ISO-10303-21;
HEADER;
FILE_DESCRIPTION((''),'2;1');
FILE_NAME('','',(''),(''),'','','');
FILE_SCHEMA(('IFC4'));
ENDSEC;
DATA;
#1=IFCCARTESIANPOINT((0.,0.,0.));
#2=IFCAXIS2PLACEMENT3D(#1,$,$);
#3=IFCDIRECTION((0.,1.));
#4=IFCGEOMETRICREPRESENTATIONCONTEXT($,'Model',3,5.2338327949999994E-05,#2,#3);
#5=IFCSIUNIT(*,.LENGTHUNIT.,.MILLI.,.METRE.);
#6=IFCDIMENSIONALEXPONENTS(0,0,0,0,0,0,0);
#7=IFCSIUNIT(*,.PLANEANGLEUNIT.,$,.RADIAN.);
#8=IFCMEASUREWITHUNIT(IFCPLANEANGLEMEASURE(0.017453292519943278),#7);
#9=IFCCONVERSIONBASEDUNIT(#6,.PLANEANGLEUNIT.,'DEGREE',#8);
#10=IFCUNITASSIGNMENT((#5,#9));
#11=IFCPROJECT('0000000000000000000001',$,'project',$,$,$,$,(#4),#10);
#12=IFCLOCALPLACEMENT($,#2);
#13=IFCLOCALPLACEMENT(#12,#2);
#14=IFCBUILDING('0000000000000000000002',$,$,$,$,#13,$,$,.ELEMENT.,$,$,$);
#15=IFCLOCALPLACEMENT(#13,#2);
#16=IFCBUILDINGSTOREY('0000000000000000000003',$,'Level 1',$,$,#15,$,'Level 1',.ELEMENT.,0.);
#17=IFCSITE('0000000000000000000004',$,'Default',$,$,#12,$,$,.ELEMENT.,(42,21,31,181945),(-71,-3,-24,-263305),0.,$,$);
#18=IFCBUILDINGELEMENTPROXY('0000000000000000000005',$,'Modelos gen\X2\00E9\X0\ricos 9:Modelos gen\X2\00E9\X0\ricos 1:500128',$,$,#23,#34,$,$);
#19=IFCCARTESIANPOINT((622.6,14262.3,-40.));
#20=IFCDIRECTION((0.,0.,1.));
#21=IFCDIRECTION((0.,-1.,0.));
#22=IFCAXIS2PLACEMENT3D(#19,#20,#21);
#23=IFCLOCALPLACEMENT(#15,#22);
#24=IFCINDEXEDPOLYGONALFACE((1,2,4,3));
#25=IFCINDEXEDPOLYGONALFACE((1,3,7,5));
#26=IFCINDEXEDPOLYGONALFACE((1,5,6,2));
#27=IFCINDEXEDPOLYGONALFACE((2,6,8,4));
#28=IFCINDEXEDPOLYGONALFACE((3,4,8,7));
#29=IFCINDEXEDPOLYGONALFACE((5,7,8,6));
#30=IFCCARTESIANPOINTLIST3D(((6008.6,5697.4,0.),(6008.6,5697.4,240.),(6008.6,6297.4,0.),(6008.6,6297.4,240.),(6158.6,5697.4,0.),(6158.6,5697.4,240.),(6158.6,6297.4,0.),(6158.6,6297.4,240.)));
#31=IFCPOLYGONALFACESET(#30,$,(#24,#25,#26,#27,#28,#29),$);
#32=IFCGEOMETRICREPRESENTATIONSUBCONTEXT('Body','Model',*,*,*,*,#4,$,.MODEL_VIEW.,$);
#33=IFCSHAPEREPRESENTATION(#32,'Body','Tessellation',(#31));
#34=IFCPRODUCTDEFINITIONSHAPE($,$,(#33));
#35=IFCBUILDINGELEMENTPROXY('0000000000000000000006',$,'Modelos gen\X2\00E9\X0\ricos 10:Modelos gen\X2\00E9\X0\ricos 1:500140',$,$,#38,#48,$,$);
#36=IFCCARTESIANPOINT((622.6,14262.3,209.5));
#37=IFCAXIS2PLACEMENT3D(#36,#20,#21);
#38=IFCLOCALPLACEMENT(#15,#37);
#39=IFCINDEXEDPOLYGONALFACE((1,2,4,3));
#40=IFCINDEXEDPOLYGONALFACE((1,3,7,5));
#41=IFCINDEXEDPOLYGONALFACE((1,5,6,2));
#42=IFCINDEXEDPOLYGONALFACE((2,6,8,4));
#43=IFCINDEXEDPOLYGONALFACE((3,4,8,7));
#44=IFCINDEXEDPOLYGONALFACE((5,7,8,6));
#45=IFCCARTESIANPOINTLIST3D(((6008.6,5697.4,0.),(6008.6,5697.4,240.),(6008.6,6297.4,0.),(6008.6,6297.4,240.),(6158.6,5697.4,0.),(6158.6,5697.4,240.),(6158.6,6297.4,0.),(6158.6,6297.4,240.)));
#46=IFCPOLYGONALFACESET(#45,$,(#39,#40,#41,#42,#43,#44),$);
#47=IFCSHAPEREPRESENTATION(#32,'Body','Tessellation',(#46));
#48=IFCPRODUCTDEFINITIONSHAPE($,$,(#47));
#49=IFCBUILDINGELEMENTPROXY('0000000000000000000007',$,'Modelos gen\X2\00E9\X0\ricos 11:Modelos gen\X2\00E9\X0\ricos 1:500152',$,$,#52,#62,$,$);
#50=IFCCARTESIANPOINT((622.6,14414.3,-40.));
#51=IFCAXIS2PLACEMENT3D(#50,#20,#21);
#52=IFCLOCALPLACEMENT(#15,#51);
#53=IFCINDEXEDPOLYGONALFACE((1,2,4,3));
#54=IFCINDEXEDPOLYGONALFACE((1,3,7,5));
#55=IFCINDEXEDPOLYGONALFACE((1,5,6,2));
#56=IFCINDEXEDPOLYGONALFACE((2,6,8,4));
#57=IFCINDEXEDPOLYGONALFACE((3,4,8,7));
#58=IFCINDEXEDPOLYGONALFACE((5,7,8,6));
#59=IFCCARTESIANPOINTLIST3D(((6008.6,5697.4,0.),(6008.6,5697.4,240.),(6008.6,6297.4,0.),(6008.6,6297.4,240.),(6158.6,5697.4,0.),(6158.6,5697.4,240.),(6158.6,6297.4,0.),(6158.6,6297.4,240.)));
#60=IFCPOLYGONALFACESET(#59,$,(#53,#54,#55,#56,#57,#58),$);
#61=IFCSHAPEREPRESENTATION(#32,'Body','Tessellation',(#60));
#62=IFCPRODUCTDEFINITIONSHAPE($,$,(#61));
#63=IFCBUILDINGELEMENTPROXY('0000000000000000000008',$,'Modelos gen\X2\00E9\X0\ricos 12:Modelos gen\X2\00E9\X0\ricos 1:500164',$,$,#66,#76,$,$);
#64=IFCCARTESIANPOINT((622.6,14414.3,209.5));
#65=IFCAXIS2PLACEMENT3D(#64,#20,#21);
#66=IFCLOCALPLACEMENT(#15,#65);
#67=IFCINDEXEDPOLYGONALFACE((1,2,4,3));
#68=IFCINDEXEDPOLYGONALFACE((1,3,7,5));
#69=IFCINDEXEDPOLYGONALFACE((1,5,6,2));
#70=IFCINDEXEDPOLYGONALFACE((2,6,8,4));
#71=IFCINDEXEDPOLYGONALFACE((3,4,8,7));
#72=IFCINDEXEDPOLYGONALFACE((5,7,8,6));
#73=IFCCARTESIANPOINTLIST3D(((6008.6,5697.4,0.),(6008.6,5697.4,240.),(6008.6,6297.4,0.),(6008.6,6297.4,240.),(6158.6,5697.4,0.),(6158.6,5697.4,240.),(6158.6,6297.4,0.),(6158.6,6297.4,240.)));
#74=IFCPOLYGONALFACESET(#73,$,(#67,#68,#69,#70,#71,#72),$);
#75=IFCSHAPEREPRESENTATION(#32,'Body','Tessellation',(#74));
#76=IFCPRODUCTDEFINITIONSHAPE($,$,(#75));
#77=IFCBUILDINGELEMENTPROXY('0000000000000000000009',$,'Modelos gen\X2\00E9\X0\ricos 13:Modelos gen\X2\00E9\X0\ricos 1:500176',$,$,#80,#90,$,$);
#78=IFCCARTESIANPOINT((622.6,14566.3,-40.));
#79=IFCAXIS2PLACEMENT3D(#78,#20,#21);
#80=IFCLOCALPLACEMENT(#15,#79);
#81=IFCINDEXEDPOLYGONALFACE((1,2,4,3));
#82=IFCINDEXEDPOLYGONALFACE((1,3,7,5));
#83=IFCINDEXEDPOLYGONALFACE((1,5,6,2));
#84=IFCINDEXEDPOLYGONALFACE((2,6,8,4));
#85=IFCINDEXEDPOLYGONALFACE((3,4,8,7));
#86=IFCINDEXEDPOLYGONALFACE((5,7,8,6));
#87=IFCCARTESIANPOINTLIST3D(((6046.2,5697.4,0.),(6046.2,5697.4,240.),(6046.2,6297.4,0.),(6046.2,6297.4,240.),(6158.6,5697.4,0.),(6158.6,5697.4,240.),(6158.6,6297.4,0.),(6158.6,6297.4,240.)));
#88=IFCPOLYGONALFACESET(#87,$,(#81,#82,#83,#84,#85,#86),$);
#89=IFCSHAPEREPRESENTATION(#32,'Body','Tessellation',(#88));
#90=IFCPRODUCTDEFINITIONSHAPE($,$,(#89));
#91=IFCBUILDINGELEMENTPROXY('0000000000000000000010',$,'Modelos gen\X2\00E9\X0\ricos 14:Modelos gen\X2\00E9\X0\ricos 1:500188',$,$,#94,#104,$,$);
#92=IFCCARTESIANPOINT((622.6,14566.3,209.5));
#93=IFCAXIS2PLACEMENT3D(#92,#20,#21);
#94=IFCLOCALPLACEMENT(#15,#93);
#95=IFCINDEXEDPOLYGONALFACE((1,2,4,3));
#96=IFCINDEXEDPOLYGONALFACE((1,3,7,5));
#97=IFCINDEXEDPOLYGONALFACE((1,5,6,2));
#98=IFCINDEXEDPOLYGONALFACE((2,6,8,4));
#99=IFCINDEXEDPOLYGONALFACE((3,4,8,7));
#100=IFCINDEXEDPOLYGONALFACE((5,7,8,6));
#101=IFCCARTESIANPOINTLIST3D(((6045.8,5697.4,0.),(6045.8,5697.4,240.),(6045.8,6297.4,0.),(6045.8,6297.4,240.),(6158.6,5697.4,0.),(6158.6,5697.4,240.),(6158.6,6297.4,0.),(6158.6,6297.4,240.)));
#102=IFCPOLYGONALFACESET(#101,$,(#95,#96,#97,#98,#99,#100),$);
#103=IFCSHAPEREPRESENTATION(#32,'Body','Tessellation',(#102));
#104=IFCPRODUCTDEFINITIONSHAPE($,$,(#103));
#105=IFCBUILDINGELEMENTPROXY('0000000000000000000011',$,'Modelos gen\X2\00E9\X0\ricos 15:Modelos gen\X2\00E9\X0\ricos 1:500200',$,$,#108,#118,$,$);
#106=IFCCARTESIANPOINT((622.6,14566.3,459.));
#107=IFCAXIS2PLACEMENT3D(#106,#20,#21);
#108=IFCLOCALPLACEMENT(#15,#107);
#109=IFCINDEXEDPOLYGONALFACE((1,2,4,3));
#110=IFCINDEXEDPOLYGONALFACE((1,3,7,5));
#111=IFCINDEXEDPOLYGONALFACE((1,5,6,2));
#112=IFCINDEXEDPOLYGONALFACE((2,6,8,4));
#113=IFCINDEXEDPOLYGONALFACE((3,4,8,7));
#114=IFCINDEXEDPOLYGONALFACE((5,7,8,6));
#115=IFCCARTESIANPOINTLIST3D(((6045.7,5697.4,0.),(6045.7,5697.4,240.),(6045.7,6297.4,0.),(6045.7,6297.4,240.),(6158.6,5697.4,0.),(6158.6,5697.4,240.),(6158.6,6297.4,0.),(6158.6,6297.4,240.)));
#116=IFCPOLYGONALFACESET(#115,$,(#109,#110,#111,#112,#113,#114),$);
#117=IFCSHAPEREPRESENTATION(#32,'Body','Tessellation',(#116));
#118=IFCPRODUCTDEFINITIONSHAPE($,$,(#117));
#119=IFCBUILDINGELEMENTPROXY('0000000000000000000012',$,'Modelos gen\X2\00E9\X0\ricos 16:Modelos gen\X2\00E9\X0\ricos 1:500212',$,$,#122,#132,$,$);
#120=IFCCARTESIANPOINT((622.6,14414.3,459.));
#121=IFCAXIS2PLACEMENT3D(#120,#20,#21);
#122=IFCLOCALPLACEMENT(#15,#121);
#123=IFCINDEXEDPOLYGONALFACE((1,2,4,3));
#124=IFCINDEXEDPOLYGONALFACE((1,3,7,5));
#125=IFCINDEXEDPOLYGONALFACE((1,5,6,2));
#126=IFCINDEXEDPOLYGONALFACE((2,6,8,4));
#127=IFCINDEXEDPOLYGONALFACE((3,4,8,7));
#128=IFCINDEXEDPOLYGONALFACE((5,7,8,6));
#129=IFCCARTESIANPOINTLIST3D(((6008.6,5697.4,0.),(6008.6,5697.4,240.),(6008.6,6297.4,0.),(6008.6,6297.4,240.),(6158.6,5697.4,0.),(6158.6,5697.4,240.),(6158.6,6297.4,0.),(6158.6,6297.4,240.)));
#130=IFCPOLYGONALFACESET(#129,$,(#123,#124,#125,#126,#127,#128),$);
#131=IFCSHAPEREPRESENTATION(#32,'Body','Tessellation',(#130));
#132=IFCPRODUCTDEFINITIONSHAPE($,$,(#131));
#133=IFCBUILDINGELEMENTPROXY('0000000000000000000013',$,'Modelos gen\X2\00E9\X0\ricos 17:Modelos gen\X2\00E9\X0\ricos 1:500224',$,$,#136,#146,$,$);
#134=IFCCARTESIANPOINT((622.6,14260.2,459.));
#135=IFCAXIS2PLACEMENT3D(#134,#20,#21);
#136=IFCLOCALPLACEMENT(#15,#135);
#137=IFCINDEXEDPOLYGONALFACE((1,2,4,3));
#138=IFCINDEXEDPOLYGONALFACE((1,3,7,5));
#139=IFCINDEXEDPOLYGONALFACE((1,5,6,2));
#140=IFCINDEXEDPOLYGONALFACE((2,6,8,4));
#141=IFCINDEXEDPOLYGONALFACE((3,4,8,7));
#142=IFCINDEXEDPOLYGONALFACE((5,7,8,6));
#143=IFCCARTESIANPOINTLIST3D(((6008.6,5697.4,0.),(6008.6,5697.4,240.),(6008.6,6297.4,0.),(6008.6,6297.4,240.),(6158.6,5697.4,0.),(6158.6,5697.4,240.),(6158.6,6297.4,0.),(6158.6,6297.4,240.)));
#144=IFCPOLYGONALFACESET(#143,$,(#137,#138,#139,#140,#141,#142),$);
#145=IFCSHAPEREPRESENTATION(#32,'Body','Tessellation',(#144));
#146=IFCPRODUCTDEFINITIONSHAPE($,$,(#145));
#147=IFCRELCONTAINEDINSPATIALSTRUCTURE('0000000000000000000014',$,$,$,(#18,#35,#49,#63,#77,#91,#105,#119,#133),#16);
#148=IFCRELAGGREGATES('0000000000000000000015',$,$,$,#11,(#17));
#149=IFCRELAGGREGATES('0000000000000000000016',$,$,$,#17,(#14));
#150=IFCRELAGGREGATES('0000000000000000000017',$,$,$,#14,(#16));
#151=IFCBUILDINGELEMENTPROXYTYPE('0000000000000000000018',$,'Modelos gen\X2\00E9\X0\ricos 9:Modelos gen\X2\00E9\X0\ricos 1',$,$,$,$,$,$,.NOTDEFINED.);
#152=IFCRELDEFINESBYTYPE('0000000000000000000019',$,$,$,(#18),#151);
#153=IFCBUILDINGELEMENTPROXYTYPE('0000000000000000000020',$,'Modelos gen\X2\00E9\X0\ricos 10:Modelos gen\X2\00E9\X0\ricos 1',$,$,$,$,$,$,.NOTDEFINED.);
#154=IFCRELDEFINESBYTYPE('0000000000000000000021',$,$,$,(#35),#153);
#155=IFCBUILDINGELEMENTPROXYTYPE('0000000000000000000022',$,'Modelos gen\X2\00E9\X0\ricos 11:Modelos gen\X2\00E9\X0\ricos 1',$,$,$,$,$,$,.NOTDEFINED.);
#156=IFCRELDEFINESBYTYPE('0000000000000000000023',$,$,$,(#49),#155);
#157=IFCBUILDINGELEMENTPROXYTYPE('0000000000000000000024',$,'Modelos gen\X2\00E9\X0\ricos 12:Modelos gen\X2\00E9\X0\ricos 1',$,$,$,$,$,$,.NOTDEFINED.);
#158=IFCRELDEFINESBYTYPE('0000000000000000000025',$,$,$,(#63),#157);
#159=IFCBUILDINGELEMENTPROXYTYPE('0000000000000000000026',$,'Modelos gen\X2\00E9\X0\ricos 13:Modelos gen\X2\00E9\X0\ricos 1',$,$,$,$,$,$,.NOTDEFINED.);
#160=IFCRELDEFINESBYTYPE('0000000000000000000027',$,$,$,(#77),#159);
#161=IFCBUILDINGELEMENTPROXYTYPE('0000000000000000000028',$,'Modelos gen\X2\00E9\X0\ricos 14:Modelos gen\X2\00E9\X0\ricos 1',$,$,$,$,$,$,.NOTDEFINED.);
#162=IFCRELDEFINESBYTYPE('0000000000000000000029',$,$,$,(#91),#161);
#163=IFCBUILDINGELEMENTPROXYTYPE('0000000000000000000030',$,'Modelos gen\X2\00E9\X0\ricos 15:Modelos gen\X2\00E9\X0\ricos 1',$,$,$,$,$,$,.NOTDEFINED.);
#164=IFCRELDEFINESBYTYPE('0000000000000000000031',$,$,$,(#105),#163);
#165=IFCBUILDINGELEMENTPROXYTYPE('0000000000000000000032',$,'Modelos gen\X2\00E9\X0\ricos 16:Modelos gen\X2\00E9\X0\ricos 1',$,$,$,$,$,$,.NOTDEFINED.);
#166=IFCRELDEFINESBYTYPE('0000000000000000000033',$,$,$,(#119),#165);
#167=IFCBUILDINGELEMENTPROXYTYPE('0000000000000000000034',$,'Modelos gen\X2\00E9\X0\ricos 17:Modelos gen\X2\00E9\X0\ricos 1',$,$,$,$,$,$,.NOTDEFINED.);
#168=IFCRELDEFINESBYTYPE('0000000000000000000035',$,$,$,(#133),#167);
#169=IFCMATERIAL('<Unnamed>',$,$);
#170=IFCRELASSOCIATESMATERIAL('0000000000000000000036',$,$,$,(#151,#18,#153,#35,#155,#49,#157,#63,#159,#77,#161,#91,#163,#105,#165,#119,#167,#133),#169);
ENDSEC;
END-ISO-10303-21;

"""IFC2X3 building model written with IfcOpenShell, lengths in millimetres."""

from ifc_helpers import new_model, entity, si_unit, converted_unit, direction, frame, frame_2d, origin, origin_2d_with_axis, place, context, subcontext, project, spatial, rectangle, extrude, source, transform, mapped, material, type_object, type_shapes, element, save


model = new_model("IFC2X3")

# Units and contexts
model_context = context("Model", 3, precision=5.2338327949999994e-05, world=origin(), true_north=direction((0.0, 1.0)))
body_context = subcontext(model_context, "Body", "Model", "MODEL_VIEW")
ifc_project = project(units=[si_unit("LENGTHUNIT", "METRE", prefix="MILLI"), converted_unit("PLANEANGLEUNIT", "DEGREE", entity("IfcPlaneAngleMeasure", 0.017453292519943278), si_unit("PLANEANGLEUNIT", "RADIAN"), dimensions=[0, 0, 0, 0, 0, 0, 0])], contexts=[model_context])

# Site, building, storey
site_placement = place(None, origin())
site = spatial("IfcSite", under=ifc_project, at=site_placement, Name="Default", CompositionType="ELEMENT", RefLatitude=(42, 21, 31, 181945), RefLongitude=(-71, -3, -24, -263305), RefElevation=0.0)
building_placement = place(site_placement, origin())
building = spatial("IfcBuilding", under=site, at=building_placement, CompositionType="ELEMENT")
storey_placement = place(building_placement, origin())
storey = spatial("IfcBuildingStorey", under=building, at=storey_placement, Name="Level 1", LongName="Level 1", CompositionType="ELEMENT", Elevation=0.0)

# Building element proxies
ifc_material_1 = material(Name="<Unnamed>")
building_element_proxy_type_1 = type_object("IfcBuildingElementProxyType", Name="Modelos genéricos 9:Modelos genéricos 1", PredefinedType="NOTDEFINED", material=ifc_material_1)
shared_shape_1 = source(origin(), body_context, "Body", "SweptSolid", [
    extrude(rectangle(XDim=150.0, YDim=600.0, at=origin_2d_with_axis()), frame((6083.6, 5997.4, 0.0), z_axis=(0.0, 0.0, 1.0), x_axis=(-1.0, 0.0, 0.0)), (0.0, 0.0, 1.0), 240.0),
])
type_shapes(building_element_proxy_type_1, [shared_shape_1])
proxy_1_placement = place(storey_placement, frame((622.6, 14262.3, -40.0), z_axis=(0.0, 0.0, 1.0), x_axis=(0.0, -1.0, 0.0)))
element("IfcBuildingElementProxy", 1, at=proxy_1_placement, inside=storey, type_object=building_element_proxy_type_1, material=ifc_material_1, Name="Modelos genéricos 9:Modelos genéricos 1:500128", context=body_context, shape_type="MappedRepresentation", body=[
    mapped(shared_shape_1, transform((0.0, 0.0, 0.0), scale=1.0)),
])
building_element_proxy_type_2 = type_object("IfcBuildingElementProxyType", Name="Modelos genéricos 10:Modelos genéricos 1", PredefinedType="NOTDEFINED", material=ifc_material_1)
shared_shape_2 = source(origin(), body_context, "Body", "SweptSolid", [
    extrude(rectangle(XDim=150.0, YDim=600.0, at=origin_2d_with_axis()), frame((6083.6, 5997.4, 0.0), z_axis=(0.0, 0.0, 1.0), x_axis=(-1.0, 0.0, 0.0)), (0.0, 0.0, 1.0), 240.0),
])
type_shapes(building_element_proxy_type_2, [shared_shape_2])
proxy_2_placement = place(storey_placement, frame((622.6, 14262.3, 209.5), z_axis=(0.0, 0.0, 1.0), x_axis=(0.0, -1.0, 0.0)))
element("IfcBuildingElementProxy", 2, at=proxy_2_placement, inside=storey, type_object=building_element_proxy_type_2, material=ifc_material_1, Name="Modelos genéricos 10:Modelos genéricos 1:500140", context=body_context, shape_type="MappedRepresentation", body=[
    mapped(shared_shape_2, transform((0.0, 0.0, 0.0), scale=1.0)),
])
building_element_proxy_type_3 = type_object("IfcBuildingElementProxyType", Name="Modelos genéricos 11:Modelos genéricos 1", PredefinedType="NOTDEFINED", material=ifc_material_1)
shared_shape_3 = source(origin(), body_context, "Body", "SweptSolid", [
    extrude(rectangle(XDim=150.0, YDim=600.0, at=origin_2d_with_axis()), frame((6083.6, 5997.4, 0.0), z_axis=(0.0, 0.0, 1.0), x_axis=(-1.0, 0.0, 0.0)), (0.0, 0.0, 1.0), 240.0),
])
type_shapes(building_element_proxy_type_3, [shared_shape_3])
proxy_3_placement = place(storey_placement, frame((622.6, 14414.3, -40.0), z_axis=(0.0, 0.0, 1.0), x_axis=(0.0, -1.0, 0.0)))
element("IfcBuildingElementProxy", 3, at=proxy_3_placement, inside=storey, type_object=building_element_proxy_type_3, material=ifc_material_1, Name="Modelos genéricos 11:Modelos genéricos 1:500152", context=body_context, shape_type="MappedRepresentation", body=[
    mapped(shared_shape_3, transform((0.0, 0.0, 0.0), scale=1.0)),
])
building_element_proxy_type_4 = type_object("IfcBuildingElementProxyType", Name="Modelos genéricos 12:Modelos genéricos 1", PredefinedType="NOTDEFINED", material=ifc_material_1)
shared_shape_4 = source(origin(), body_context, "Body", "SweptSolid", [
    extrude(rectangle(XDim=150.0, YDim=600.0, at=origin_2d_with_axis()), frame((6083.6, 5997.4, 0.0), z_axis=(0.0, 0.0, 1.0), x_axis=(-1.0, 0.0, 0.0)), (0.0, 0.0, 1.0), 240.0),
])
type_shapes(building_element_proxy_type_4, [shared_shape_4])
proxy_4_placement = place(storey_placement, frame((622.6, 14414.3, 209.5), z_axis=(0.0, 0.0, 1.0), x_axis=(0.0, -1.0, 0.0)))
element("IfcBuildingElementProxy", 4, at=proxy_4_placement, inside=storey, type_object=building_element_proxy_type_4, material=ifc_material_1, Name="Modelos genéricos 12:Modelos genéricos 1:500164", context=body_context, shape_type="MappedRepresentation", body=[
    mapped(shared_shape_4, transform((0.0, 0.0, 0.0), scale=1.0)),
])
building_element_proxy_type_5 = type_object("IfcBuildingElementProxyType", Name="Modelos genéricos 13:Modelos genéricos 1", PredefinedType="NOTDEFINED", material=ifc_material_1)
shared_shape_5 = source(origin(), body_context, "Body", "SweptSolid", [
    extrude(rectangle(XDim=112.4, YDim=600.0, at=frame_2d((0.0, 0.0), x_axis=(1.0, 0.0))), frame((6102.4, 5997.4, 0.0), z_axis=(0.0, 0.0, 1.0), x_axis=(-1.0, 0.0, 0.0)), (0.0, 0.0, 1.0), 240.0),
])
type_shapes(building_element_proxy_type_5, [shared_shape_5])
proxy_5_placement = place(storey_placement, frame((622.6, 14566.3, -40.0), z_axis=(0.0, 0.0, 1.0), x_axis=(0.0, -1.0, 0.0)))
element("IfcBuildingElementProxy", 5, at=proxy_5_placement, inside=storey, type_object=building_element_proxy_type_5, material=ifc_material_1, Name="Modelos genéricos 13:Modelos genéricos 1:500176", context=body_context, shape_type="MappedRepresentation", body=[
    mapped(shared_shape_5, transform((0.0, 0.0, 0.0), scale=1.0)),
])
building_element_proxy_type_6 = type_object("IfcBuildingElementProxyType", Name="Modelos genéricos 14:Modelos genéricos 1", PredefinedType="NOTDEFINED", material=ifc_material_1)
shared_shape_6 = source(origin(), body_context, "Body", "SweptSolid", [
    extrude(rectangle(XDim=112.8, YDim=600.0, at=frame_2d((0.0, 0.0), x_axis=(1.0, 0.0))), frame((6102.2, 5997.4, 0.0), z_axis=(0.0, 0.0, 1.0), x_axis=(-1.0, 0.0, 0.0)), (0.0, 0.0, 1.0), 240.0),
])
type_shapes(building_element_proxy_type_6, [shared_shape_6])
proxy_6_placement = place(storey_placement, frame((622.6, 14566.3, 209.5), z_axis=(0.0, 0.0, 1.0), x_axis=(0.0, -1.0, 0.0)))
element("IfcBuildingElementProxy", 6, at=proxy_6_placement, inside=storey, type_object=building_element_proxy_type_6, material=ifc_material_1, Name="Modelos genéricos 14:Modelos genéricos 1:500188", context=body_context, shape_type="MappedRepresentation", body=[
    mapped(shared_shape_6, transform((0.0, 0.0, 0.0), scale=1.0)),
])
building_element_proxy_type_7 = type_object("IfcBuildingElementProxyType", Name="Modelos genéricos 15:Modelos genéricos 1", PredefinedType="NOTDEFINED", material=ifc_material_1)
shared_shape_7 = source(origin(), body_context, "Body", "SweptSolid", [
    extrude(rectangle(XDim=112.9, YDim=600.0, at=origin_2d_with_axis()), frame((6102.2, 5997.4, 0.0), z_axis=(0.0, 0.0, 1.0), x_axis=(-1.0, 0.0, 0.0)), (0.0, 0.0, 1.0), 240.0),
])
type_shapes(building_element_proxy_type_7, [shared_shape_7])
proxy_7_placement = place(storey_placement, frame((622.6, 14566.3, 459.0), z_axis=(0.0, 0.0, 1.0), x_axis=(0.0, -1.0, 0.0)))
element("IfcBuildingElementProxy", 7, at=proxy_7_placement, inside=storey, type_object=building_element_proxy_type_7, material=ifc_material_1, Name="Modelos genéricos 15:Modelos genéricos 1:500200", context=body_context, shape_type="MappedRepresentation", body=[
    mapped(shared_shape_7, transform((0.0, 0.0, 0.0), scale=1.0)),
])
building_element_proxy_type_8 = type_object("IfcBuildingElementProxyType", Name="Modelos genéricos 16:Modelos genéricos 1", PredefinedType="NOTDEFINED", material=ifc_material_1)
shared_shape_8 = source(origin(), body_context, "Body", "SweptSolid", [
    extrude(rectangle(XDim=150.0, YDim=600.0, at=origin_2d_with_axis()), frame((6083.6, 5997.4, 0.0), z_axis=(0.0, 0.0, 1.0), x_axis=(-1.0, 0.0, 0.0)), (0.0, 0.0, 1.0), 240.0),
])
type_shapes(building_element_proxy_type_8, [shared_shape_8])
proxy_8_placement = place(storey_placement, frame((622.6, 14414.3, 459.0), z_axis=(0.0, 0.0, 1.0), x_axis=(0.0, -1.0, 0.0)))
element("IfcBuildingElementProxy", 8, at=proxy_8_placement, inside=storey, type_object=building_element_proxy_type_8, material=ifc_material_1, Name="Modelos genéricos 16:Modelos genéricos 1:500212", context=body_context, shape_type="MappedRepresentation", body=[
    mapped(shared_shape_8, transform((0.0, 0.0, 0.0), scale=1.0)),
])
building_element_proxy_type_9 = type_object("IfcBuildingElementProxyType", Name="Modelos genéricos 17:Modelos genéricos 1", PredefinedType="NOTDEFINED", material=ifc_material_1)
shared_shape_9 = source(origin(), body_context, "Body", "SweptSolid", [
    extrude(rectangle(XDim=150.0, YDim=600.0, at=origin_2d_with_axis()), frame((6083.6, 5997.4, 0.0), z_axis=(0.0, 0.0, 1.0), x_axis=(-1.0, 0.0, 0.0)), (0.0, 0.0, 1.0), 240.0),
])
type_shapes(building_element_proxy_type_9, [shared_shape_9])
proxy_9_placement = place(storey_placement, frame((622.6, 14260.2, 459.0), z_axis=(0.0, 0.0, 1.0), x_axis=(0.0, -1.0, 0.0)))
element("IfcBuildingElementProxy", 9, at=proxy_9_placement, inside=storey, type_object=building_element_proxy_type_9, material=ifc_material_1, Name="Modelos genéricos 17:Modelos genéricos 1:500224", context=body_context, shape_type="MappedRepresentation", body=[
    mapped(shared_shape_9, transform((0.0, 0.0, 0.0), scale=1.0)),
])

save(model, "model.ifc")
